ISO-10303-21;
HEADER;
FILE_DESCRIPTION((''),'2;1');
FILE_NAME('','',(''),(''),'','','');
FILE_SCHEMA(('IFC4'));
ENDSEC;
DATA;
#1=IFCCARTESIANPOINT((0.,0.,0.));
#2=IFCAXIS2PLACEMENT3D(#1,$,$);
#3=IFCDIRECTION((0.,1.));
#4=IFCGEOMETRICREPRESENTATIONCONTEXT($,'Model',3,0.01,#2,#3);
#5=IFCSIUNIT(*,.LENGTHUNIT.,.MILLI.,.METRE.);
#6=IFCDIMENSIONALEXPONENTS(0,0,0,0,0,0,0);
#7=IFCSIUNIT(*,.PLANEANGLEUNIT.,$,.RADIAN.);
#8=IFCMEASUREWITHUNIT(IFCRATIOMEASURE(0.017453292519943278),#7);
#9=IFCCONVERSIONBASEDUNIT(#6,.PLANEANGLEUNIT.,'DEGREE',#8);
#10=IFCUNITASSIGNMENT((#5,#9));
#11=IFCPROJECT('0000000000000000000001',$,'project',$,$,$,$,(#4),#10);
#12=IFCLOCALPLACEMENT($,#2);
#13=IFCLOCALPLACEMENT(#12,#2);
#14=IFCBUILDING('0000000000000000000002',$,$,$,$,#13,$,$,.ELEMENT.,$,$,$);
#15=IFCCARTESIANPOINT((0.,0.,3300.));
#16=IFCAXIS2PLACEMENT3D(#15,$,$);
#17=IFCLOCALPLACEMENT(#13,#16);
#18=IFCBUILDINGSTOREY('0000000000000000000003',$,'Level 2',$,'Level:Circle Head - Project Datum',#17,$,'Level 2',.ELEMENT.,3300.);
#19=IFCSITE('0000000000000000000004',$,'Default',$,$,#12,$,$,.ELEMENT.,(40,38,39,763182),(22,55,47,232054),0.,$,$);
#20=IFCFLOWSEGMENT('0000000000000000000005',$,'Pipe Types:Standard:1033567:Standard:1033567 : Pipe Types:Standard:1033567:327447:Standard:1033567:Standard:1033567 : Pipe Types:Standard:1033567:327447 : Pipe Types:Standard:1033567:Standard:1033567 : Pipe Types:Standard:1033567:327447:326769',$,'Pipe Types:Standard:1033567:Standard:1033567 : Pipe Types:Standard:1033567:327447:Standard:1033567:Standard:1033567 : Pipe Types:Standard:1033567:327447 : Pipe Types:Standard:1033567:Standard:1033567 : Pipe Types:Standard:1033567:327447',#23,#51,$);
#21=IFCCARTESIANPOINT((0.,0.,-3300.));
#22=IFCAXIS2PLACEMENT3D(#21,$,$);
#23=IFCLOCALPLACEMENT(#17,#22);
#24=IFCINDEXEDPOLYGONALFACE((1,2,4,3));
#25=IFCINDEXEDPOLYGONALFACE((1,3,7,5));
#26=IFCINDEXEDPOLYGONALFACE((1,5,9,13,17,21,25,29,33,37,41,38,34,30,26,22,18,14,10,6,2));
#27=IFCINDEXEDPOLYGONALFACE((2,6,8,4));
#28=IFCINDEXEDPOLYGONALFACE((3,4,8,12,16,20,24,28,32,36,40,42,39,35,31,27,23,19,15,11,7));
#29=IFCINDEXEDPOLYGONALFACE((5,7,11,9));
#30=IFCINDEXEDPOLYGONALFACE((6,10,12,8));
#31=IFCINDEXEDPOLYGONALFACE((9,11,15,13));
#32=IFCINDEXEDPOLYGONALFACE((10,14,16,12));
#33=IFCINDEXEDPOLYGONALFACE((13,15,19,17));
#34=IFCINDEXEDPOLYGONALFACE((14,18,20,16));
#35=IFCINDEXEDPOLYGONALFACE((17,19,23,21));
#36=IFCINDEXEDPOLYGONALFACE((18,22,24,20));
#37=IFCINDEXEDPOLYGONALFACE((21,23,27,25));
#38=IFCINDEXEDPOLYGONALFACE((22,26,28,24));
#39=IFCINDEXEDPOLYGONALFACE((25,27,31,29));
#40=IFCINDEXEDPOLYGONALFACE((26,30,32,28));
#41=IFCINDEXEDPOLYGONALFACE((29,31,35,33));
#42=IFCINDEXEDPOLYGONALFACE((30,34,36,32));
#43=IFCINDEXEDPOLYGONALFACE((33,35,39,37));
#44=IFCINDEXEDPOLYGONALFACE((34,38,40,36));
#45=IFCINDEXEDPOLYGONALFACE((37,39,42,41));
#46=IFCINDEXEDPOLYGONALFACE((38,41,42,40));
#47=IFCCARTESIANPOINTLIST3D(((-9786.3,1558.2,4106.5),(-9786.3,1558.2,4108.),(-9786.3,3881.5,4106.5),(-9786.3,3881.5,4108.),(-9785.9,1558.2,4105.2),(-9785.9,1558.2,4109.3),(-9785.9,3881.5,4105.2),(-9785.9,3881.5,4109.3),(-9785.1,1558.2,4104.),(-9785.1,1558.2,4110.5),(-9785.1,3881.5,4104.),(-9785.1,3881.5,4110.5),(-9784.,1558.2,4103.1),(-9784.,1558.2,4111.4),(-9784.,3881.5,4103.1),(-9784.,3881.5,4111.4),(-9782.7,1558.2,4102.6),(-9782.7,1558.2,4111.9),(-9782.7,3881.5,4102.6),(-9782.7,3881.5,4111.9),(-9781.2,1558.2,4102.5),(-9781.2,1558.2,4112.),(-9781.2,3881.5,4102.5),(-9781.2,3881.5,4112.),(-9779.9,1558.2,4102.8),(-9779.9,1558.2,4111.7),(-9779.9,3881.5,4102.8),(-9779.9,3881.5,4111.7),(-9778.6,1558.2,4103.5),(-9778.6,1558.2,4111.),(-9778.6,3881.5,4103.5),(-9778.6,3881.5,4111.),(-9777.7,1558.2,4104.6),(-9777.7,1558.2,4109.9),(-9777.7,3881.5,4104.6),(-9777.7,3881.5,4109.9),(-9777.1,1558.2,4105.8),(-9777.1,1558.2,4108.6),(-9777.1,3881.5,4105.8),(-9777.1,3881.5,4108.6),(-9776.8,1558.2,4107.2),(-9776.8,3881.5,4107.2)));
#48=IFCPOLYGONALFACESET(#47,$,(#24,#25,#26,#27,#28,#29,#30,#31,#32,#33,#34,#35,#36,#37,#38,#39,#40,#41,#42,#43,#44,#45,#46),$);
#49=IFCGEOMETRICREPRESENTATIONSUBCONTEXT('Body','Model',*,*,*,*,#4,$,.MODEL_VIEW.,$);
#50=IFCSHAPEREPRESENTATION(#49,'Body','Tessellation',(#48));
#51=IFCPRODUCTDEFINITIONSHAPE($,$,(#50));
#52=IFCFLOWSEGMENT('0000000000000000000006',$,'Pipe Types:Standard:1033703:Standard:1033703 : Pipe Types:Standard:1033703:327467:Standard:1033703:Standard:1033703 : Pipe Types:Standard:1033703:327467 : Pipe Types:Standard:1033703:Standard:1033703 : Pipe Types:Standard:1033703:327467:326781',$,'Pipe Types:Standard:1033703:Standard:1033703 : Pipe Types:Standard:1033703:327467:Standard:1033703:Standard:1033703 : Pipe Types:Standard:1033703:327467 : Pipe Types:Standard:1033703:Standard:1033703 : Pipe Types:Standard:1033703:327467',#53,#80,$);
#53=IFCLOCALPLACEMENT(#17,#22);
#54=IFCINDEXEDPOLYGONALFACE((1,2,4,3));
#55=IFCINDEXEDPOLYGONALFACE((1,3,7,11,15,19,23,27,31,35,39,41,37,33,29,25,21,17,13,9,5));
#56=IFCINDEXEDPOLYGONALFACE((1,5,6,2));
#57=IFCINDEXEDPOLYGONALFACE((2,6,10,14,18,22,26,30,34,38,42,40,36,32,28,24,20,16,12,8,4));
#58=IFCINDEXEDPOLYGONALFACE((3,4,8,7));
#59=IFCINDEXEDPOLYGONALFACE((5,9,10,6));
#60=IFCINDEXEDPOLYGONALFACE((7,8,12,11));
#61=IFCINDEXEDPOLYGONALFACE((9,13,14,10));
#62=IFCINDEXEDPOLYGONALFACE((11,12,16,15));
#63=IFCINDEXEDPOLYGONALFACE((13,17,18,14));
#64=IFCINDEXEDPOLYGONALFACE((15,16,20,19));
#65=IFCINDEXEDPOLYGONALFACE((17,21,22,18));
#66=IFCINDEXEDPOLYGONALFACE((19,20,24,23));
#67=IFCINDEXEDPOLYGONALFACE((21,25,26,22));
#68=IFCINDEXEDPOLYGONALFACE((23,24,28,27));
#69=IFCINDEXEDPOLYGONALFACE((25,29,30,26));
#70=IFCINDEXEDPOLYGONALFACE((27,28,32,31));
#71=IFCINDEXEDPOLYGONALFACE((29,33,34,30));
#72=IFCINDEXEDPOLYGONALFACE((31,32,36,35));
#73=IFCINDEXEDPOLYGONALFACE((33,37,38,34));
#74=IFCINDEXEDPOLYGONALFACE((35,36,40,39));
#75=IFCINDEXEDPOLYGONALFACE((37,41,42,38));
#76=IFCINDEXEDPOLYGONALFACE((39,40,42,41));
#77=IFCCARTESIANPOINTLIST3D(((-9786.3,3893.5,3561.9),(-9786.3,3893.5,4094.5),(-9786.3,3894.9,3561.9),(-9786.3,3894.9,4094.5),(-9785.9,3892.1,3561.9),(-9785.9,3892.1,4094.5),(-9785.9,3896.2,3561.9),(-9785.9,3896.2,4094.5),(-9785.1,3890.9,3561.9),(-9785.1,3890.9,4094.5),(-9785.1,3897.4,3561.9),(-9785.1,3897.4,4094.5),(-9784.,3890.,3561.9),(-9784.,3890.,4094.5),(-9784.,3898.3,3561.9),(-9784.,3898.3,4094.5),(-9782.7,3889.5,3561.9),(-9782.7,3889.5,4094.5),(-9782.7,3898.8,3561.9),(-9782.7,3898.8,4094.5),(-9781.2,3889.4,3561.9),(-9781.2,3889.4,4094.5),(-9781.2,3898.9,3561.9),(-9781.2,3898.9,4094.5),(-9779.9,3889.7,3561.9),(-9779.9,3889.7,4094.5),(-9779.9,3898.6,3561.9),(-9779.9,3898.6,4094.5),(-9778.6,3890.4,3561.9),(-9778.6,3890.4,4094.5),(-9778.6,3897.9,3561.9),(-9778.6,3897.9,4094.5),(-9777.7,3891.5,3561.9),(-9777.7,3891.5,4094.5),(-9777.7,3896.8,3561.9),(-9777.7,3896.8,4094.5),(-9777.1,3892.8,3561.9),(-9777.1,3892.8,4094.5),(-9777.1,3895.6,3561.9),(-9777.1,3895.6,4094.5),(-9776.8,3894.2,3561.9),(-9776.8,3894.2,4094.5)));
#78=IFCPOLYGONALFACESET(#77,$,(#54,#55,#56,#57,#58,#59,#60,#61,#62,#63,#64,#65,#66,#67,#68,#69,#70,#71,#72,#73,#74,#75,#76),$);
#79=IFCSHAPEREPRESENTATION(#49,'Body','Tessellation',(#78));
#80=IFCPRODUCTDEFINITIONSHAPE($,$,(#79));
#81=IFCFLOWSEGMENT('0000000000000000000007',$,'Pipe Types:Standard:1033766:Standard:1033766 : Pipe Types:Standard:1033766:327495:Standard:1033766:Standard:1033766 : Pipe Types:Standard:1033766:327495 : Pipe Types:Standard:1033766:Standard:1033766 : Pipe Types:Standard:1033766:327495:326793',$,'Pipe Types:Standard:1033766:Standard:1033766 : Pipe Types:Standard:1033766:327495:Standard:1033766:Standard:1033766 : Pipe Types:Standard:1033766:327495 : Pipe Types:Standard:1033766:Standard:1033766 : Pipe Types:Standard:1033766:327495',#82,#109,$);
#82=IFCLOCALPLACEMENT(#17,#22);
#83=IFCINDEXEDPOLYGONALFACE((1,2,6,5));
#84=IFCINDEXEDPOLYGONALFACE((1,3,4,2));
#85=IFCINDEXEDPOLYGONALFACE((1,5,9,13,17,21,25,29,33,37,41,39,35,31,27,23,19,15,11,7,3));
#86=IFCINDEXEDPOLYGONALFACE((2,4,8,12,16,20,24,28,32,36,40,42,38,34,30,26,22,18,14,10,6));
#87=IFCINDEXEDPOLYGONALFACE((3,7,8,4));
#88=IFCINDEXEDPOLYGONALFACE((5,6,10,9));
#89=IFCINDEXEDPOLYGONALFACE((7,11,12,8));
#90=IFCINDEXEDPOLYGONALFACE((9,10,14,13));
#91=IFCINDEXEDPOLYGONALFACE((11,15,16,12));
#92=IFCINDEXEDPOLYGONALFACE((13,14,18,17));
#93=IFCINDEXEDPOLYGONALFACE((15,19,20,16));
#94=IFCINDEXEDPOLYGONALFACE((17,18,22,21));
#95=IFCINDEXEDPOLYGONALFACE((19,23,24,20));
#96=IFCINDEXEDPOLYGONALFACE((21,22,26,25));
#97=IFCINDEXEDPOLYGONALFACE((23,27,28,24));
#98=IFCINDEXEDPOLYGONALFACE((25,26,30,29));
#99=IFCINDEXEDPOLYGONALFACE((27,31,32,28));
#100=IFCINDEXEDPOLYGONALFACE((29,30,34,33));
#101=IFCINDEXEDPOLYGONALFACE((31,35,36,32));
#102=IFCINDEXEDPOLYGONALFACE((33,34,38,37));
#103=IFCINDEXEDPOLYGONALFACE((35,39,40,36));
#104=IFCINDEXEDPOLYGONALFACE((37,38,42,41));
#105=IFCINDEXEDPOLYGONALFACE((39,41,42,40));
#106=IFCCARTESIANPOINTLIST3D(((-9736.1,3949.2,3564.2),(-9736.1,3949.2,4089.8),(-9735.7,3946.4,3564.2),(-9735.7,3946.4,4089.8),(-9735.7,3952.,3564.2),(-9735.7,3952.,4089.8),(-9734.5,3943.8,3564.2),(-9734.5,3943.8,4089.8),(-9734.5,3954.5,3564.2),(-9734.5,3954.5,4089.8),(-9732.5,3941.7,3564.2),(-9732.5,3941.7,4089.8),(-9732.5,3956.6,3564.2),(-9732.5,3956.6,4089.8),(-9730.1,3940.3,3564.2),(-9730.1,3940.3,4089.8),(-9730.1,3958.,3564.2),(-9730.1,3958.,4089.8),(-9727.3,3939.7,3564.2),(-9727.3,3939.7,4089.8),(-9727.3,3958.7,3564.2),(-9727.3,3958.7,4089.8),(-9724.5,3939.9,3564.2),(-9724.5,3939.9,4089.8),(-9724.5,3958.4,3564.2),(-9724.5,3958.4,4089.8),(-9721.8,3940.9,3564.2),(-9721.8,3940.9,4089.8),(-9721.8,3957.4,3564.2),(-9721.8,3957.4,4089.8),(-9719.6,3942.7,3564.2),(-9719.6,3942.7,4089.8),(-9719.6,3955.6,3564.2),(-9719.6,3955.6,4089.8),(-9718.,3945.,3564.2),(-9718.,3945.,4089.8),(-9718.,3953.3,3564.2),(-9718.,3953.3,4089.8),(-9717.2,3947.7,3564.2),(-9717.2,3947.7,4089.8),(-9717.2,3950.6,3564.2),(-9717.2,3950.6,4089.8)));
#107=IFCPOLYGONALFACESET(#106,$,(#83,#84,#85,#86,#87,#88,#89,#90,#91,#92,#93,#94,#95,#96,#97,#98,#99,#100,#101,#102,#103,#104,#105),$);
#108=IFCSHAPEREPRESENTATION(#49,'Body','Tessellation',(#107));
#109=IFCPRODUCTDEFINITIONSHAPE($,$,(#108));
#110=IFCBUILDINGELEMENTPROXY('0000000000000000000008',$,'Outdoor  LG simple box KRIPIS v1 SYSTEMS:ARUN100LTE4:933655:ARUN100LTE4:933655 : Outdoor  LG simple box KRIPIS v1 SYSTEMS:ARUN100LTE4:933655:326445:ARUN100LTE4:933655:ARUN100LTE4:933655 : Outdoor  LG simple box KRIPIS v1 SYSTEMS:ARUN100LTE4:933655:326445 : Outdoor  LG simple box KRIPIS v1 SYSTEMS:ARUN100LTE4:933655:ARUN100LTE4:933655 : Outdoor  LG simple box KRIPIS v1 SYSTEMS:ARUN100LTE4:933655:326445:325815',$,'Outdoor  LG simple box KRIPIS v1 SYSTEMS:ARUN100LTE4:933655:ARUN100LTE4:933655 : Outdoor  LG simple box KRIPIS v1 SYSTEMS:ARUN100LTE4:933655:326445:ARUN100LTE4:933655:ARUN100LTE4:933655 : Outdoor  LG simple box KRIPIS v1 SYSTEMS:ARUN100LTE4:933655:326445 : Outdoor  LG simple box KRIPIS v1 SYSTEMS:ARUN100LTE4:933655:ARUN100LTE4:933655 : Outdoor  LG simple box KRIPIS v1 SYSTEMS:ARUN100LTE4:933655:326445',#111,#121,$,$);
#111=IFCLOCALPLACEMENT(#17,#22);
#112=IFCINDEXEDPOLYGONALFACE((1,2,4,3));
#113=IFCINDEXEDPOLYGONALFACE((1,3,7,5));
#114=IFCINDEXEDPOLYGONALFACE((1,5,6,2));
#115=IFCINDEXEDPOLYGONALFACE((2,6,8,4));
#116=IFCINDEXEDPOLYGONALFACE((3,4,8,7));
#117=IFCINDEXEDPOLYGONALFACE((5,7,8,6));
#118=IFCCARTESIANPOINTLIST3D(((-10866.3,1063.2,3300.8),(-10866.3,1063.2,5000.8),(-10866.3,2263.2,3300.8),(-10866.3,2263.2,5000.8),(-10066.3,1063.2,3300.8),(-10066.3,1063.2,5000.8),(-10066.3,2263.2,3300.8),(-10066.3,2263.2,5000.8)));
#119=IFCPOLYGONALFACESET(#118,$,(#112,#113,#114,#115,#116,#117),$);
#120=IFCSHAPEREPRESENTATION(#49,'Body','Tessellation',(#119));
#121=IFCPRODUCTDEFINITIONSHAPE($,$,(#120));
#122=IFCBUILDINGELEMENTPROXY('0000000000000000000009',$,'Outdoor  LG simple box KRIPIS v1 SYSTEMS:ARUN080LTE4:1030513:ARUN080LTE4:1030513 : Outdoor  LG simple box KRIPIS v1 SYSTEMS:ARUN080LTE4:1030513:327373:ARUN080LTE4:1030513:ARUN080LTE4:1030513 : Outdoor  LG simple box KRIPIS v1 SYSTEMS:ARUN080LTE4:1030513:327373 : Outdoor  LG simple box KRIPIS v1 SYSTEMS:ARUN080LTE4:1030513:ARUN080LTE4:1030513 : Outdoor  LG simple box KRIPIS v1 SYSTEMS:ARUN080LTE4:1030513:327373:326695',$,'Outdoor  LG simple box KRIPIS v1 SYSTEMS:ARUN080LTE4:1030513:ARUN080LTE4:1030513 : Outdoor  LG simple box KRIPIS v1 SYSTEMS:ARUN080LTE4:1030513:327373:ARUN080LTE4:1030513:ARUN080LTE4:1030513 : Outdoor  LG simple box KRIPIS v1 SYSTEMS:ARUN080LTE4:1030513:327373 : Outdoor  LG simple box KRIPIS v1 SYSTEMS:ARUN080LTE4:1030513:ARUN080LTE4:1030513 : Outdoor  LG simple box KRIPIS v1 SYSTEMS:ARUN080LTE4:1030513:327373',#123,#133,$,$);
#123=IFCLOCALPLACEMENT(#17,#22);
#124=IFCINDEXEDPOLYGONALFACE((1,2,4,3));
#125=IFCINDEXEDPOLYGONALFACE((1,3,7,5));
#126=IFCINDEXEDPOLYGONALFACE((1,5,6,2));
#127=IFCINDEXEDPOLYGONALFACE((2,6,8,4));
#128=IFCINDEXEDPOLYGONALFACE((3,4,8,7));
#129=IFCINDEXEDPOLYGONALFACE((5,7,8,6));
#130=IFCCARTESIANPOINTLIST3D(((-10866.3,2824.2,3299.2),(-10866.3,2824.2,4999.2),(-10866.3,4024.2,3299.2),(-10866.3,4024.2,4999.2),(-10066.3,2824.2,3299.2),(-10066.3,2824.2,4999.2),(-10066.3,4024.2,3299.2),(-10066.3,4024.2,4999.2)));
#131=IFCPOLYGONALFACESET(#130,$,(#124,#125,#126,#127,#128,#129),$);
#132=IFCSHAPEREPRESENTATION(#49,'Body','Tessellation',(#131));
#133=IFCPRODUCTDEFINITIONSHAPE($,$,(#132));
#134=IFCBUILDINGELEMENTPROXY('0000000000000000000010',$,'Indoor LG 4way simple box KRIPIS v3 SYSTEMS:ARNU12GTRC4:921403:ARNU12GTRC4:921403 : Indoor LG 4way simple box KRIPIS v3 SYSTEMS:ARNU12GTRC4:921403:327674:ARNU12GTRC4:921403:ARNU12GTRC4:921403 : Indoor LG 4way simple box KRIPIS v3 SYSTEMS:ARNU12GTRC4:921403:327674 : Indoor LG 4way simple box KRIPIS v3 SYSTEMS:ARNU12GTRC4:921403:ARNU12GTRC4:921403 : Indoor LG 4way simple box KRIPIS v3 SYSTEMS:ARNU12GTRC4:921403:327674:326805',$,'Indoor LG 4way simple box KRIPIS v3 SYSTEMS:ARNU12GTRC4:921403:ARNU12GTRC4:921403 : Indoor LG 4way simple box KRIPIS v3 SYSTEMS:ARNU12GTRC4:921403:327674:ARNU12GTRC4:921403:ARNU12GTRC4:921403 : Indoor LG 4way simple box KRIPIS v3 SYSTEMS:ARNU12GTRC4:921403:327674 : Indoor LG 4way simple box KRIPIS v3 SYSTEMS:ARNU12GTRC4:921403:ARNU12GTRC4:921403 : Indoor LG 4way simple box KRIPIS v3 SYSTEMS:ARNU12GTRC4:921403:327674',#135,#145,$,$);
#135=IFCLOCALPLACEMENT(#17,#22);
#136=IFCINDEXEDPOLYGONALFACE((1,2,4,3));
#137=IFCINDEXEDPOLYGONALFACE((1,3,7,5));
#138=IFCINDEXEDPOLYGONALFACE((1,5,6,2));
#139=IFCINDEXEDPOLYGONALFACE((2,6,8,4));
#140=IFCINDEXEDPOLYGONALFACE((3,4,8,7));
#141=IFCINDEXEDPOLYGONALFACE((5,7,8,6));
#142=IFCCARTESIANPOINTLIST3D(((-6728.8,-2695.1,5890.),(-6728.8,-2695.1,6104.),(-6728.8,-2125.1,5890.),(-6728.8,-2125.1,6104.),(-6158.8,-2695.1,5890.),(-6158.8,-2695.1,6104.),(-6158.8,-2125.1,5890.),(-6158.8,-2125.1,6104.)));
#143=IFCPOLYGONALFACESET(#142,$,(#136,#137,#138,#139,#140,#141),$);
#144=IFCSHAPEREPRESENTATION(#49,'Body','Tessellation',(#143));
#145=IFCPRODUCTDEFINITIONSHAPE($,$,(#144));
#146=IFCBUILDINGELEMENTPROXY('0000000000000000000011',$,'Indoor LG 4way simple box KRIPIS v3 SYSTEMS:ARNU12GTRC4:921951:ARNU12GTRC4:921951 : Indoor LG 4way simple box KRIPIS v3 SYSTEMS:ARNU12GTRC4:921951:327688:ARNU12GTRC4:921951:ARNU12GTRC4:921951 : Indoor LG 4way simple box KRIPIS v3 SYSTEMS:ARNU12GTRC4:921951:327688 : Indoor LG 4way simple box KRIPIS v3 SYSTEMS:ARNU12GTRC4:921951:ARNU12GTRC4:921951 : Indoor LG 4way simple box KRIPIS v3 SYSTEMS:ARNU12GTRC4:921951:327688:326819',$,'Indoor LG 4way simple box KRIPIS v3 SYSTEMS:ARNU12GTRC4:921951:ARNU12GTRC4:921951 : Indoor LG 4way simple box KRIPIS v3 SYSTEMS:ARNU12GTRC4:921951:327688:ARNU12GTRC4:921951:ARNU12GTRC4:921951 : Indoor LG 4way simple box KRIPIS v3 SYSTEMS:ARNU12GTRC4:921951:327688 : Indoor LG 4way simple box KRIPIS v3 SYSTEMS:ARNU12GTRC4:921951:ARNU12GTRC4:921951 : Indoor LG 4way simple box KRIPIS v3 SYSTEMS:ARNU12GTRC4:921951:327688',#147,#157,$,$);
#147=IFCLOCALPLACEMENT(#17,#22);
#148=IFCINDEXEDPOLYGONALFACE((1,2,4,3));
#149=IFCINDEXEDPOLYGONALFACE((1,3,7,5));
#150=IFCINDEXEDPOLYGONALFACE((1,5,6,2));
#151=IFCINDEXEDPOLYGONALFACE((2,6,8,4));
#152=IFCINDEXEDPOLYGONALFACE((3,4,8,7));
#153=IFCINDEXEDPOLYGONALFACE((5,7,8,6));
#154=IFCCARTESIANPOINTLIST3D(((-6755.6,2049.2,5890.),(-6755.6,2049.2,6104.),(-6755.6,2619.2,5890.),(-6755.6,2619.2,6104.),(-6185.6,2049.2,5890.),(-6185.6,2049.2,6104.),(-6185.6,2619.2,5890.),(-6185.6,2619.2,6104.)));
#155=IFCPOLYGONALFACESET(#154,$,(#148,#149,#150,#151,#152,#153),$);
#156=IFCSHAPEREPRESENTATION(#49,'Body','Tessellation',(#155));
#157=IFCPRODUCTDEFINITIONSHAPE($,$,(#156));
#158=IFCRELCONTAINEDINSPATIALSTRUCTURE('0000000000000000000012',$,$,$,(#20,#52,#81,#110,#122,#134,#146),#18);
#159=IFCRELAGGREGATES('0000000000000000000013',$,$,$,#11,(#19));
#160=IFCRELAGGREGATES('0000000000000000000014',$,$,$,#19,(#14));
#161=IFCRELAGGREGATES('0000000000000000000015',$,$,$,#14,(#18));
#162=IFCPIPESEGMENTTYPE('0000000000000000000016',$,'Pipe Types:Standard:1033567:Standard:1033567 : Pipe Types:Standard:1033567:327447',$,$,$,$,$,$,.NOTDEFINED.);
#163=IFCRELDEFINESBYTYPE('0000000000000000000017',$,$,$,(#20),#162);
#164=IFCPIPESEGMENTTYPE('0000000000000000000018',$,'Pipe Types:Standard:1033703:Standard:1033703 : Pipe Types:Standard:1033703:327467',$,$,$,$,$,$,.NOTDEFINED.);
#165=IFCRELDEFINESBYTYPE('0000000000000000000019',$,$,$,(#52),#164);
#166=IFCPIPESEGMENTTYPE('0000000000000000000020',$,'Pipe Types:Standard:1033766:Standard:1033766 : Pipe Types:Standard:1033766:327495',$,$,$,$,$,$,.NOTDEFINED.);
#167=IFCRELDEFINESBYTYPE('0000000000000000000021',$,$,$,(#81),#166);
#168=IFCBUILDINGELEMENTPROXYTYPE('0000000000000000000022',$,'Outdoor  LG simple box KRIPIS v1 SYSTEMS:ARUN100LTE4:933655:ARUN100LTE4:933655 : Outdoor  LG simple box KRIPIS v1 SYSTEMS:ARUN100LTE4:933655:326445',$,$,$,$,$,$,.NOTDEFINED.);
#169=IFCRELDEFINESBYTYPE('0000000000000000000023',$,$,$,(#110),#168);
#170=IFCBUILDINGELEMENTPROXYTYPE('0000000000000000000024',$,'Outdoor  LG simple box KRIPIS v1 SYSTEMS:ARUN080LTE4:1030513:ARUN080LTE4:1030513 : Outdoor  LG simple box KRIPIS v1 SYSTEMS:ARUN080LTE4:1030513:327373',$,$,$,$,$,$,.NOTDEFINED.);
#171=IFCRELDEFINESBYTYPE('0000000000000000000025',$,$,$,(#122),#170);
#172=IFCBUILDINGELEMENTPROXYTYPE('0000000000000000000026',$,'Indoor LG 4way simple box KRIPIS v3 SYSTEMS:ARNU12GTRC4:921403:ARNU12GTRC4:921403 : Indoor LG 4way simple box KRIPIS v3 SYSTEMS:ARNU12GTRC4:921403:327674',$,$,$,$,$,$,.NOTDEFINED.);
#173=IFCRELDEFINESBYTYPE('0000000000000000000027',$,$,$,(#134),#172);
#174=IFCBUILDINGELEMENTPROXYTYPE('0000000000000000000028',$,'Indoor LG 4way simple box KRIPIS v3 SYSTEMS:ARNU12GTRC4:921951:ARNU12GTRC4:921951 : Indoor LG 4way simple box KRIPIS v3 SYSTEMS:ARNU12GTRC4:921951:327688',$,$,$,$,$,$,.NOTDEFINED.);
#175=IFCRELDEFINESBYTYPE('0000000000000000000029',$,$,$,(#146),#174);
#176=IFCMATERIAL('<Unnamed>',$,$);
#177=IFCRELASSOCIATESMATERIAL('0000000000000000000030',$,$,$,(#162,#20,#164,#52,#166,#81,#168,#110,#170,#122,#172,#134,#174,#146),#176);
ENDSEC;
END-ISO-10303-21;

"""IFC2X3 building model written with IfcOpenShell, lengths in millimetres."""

from ifc_helpers import new_model, entity, si_unit, converted_unit, direction, frame, frame_2d, origin, origin_2d_with_axis, place, context, subcontext, project, spatial, rectangle, circle, extrude, source, transform, mapped, material, type_object, type_shapes, element, save


model = new_model("IFC2X3")

# Units and contexts
model_context = context("Model", 3, precision=0.01, world=origin(), true_north=direction((0.0, 1.0)))
body_context = subcontext(model_context, "Body", "Model", "MODEL_VIEW")
ifc_project = project(units=[si_unit("LENGTHUNIT", "METRE", prefix="MILLI"), converted_unit("PLANEANGLEUNIT", "DEGREE", entity("IfcRatioMeasure", 0.017453292519943278), si_unit("PLANEANGLEUNIT", "RADIAN"), dimensions=[0, 0, 0, 0, 0, 0, 0])], contexts=[model_context])

# Site, building, storey
site_placement = place(None, origin())
site = spatial("IfcSite", under=ifc_project, at=site_placement, Name="Default", CompositionType="ELEMENT", RefLatitude=(40, 38, 39, 763182), RefLongitude=(22, 55, 47, 232054), RefElevation=0.0)
building_placement = place(site_placement, origin())
building = spatial("IfcBuilding", under=site, at=building_placement, CompositionType="ELEMENT")
storey_placement = place(building_placement, frame((0.0, 0.0, 3300.0)))
storey = spatial("IfcBuildingStorey", under=building, at=storey_placement, Name="Level 2", ObjectType="Level:Circle Head - Project Datum", LongName="Level 2", CompositionType="ELEMENT", Elevation=3300.0)

# Flow segments
ifc_material_1 = material(Name="<Unnamed>")
pipe_segment_type_1 = type_object("IfcPipeSegmentType", Name="Pipe Types:Standard:1033567:Standard:1033567 : Pipe Types:Standard:1033567:327447", PredefinedType="NOTDEFINED", material=ifc_material_1)
shared_shape_1 = source(origin(), body_context, "Body", "SweptSolid", [
    extrude(circle(Radius=4.8, at=origin_2d_with_axis()), frame((-9781.6, 1558.2, 4107.2), z_axis=(0.0, 1.0, 0.0), x_axis=(1.0, 0.0, 0.0)), (0.0, 0.0, 1.0), 2323.3),
])
type_shapes(pipe_segment_type_1, [shared_shape_1])
flow_segment_1_placement = place(storey_placement, frame((0.0, 0.0, -3300.0)))
element("IfcFlowSegment", 1, at=flow_segment_1_placement, inside=storey, type_object=pipe_segment_type_1, material=ifc_material_1, Name="Pipe Types:Standard:1033567:Standard:1033567 : Pipe Types:Standard:1033567:327447:Standard:1033567:Standard:1033567 : Pipe Types:Standard:1033567:327447 : Pipe Types:Standard:1033567:Standard:1033567 : Pipe Types:Standard:1033567:327447:326769", ObjectType="Pipe Types:Standard:1033567:Standard:1033567 : Pipe Types:Standard:1033567:327447:Standard:1033567:Standard:1033567 : Pipe Types:Standard:1033567:327447 : Pipe Types:Standard:1033567:Standard:1033567 : Pipe Types:Standard:1033567:327447", context=body_context, shape_type="MappedRepresentation", body=[
    mapped(shared_shape_1, transform((0.0, 0.0, 0.0), scale=1.0)),
])
pipe_segment_type_2 = type_object("IfcPipeSegmentType", Name="Pipe Types:Standard:1033703:Standard:1033703 : Pipe Types:Standard:1033703:327467", PredefinedType="NOTDEFINED", material=ifc_material_1)
shared_shape_2 = source(origin(), body_context, "Body", "SweptSolid", [
    extrude(circle(Radius=4.8, at=origin_2d_with_axis()), frame((-9781.6, 3894.2, 3561.9)), (0.0, 0.0, 1.0), 532.6),
])
type_shapes(pipe_segment_type_2, [shared_shape_2])
flow_segment_2_placement = place(storey_placement, frame((0.0, 0.0, -3300.0)))
element("IfcFlowSegment", 2, at=flow_segment_2_placement, inside=storey, type_object=pipe_segment_type_2, material=ifc_material_1, Name="Pipe Types:Standard:1033703:Standard:1033703 : Pipe Types:Standard:1033703:327467:Standard:1033703:Standard:1033703 : Pipe Types:Standard:1033703:327467 : Pipe Types:Standard:1033703:Standard:1033703 : Pipe Types:Standard:1033703:327467:326781", ObjectType="Pipe Types:Standard:1033703:Standard:1033703 : Pipe Types:Standard:1033703:327467:Standard:1033703:Standard:1033703 : Pipe Types:Standard:1033703:327467 : Pipe Types:Standard:1033703:Standard:1033703 : Pipe Types:Standard:1033703:327467", context=body_context, shape_type="MappedRepresentation", body=[
    mapped(shared_shape_2, transform((0.0, 0.0, 0.0), scale=1.0)),
])
pipe_segment_type_3 = type_object("IfcPipeSegmentType", Name="Pipe Types:Standard:1033766:Standard:1033766 : Pipe Types:Standard:1033766:327495", PredefinedType="NOTDEFINED", material=ifc_material_1)
shared_shape_3 = source(origin(), body_context, "Body", "SweptSolid", [
    extrude(circle(Radius=9.5, at=origin_2d_with_axis()), frame((-9726.6, 3949.2, 3564.2), z_axis=(0.0, 0.0, 1.0), x_axis=(-1.0, 0.0, 0.0)), (0.0, 0.0, 1.0), 525.6),
])
type_shapes(pipe_segment_type_3, [shared_shape_3])
flow_segment_3_placement = place(storey_placement, frame((0.0, 0.0, -3300.0)))
element("IfcFlowSegment", 3, at=flow_segment_3_placement, inside=storey, type_object=pipe_segment_type_3, material=ifc_material_1, Name="Pipe Types:Standard:1033766:Standard:1033766 : Pipe Types:Standard:1033766:327495:Standard:1033766:Standard:1033766 : Pipe Types:Standard:1033766:327495 : Pipe Types:Standard:1033766:Standard:1033766 : Pipe Types:Standard:1033766:327495:326793", ObjectType="Pipe Types:Standard:1033766:Standard:1033766 : Pipe Types:Standard:1033766:327495:Standard:1033766:Standard:1033766 : Pipe Types:Standard:1033766:327495 : Pipe Types:Standard:1033766:Standard:1033766 : Pipe Types:Standard:1033766:327495", context=body_context, shape_type="MappedRepresentation", body=[
    mapped(shared_shape_3, transform((0.0, 0.0, 0.0), scale=1.0)),
])

# Building element proxies
building_element_proxy_type_1 = type_object("IfcBuildingElementProxyType", Name="Outdoor  LG simple box KRIPIS v1 SYSTEMS:ARUN100LTE4:933655:ARUN100LTE4:933655 : Outdoor  LG simple box KRIPIS v1 SYSTEMS:ARUN100LTE4:933655:326445", PredefinedType="NOTDEFINED", material=ifc_material_1)
shared_shape_4 = source(origin(), body_context, "Body", "SweptSolid", [
    extrude(rectangle(XDim=1200.0, YDim=800.0, at=frame_2d((0.0, 0.0), x_axis=(1.0, 0.0))), frame((-10466.3, 1663.2, 3300.8), z_axis=(0.0, 0.0, 1.0), x_axis=(0.0, -1.0, 0.0)), (0.0, 0.0, 1.0), 1700.0),
])
type_shapes(building_element_proxy_type_1, [shared_shape_4])
proxy_1_placement = place(storey_placement, frame((0.0, 0.0, -3300.0)))
element("IfcBuildingElementProxy", 4, at=proxy_1_placement, inside=storey, type_object=building_element_proxy_type_1, material=ifc_material_1, Name="Outdoor  LG simple box KRIPIS v1 SYSTEMS:ARUN100LTE4:933655:ARUN100LTE4:933655 : Outdoor  LG simple box KRIPIS v1 SYSTEMS:ARUN100LTE4:933655:326445:ARUN100LTE4:933655:ARUN100LTE4:933655 : Outdoor  LG simple box KRIPIS v1 SYSTEMS:ARUN100LTE4:933655:326445 : Outdoor  LG simple box KRIPIS v1 SYSTEMS:ARUN100LTE4:933655:ARUN100LTE4:933655 : Outdoor  LG simple box KRIPIS v1 SYSTEMS:ARUN100LTE4:933655:326445:325815", ObjectType="Outdoor  LG simple box KRIPIS v1 SYSTEMS:ARUN100LTE4:933655:ARUN100LTE4:933655 : Outdoor  LG simple box KRIPIS v1 SYSTEMS:ARUN100LTE4:933655:326445:ARUN100LTE4:933655:ARUN100LTE4:933655 : Outdoor  LG simple box KRIPIS v1 SYSTEMS:ARUN100LTE4:933655:326445 : Outdoor  LG simple box KRIPIS v1 SYSTEMS:ARUN100LTE4:933655:ARUN100LTE4:933655 : Outdoor  LG simple box KRIPIS v1 SYSTEMS:ARUN100LTE4:933655:326445", context=body_context, shape_type="MappedRepresentation", body=[
    mapped(shared_shape_4, transform((0.0, 0.0, 0.0), scale=1.0)),
])
building_element_proxy_type_2 = type_object("IfcBuildingElementProxyType", Name="Outdoor  LG simple box KRIPIS v1 SYSTEMS:ARUN080LTE4:1030513:ARUN080LTE4:1030513 : Outdoor  LG simple box KRIPIS v1 SYSTEMS:ARUN080LTE4:1030513:327373", PredefinedType="NOTDEFINED", material=ifc_material_1)
shared_shape_5 = source(origin(), body_context, "Body", "SweptSolid", [
    extrude(rectangle(XDim=1200.0, YDim=800.0, at=origin_2d_with_axis()), frame((-10466.3, 3424.2, 3299.2), z_axis=(0.0, 0.0, 1.0), x_axis=(0.0, -1.0, 0.0)), (0.0, 0.0, 1.0), 1700.0),
])
type_shapes(building_element_proxy_type_2, [shared_shape_5])
proxy_2_placement = place(storey_placement, frame((0.0, 0.0, -3300.0)))
element("IfcBuildingElementProxy", 5, at=proxy_2_placement, inside=storey, type_object=building_element_proxy_type_2, material=ifc_material_1, Name="Outdoor  LG simple box KRIPIS v1 SYSTEMS:ARUN080LTE4:1030513:ARUN080LTE4:1030513 : Outdoor  LG simple box KRIPIS v1 SYSTEMS:ARUN080LTE4:1030513:327373:ARUN080LTE4:1030513:ARUN080LTE4:1030513 : Outdoor  LG simple box KRIPIS v1 SYSTEMS:ARUN080LTE4:1030513:327373 : Outdoor  LG simple box KRIPIS v1 SYSTEMS:ARUN080LTE4:1030513:ARUN080LTE4:1030513 : Outdoor  LG simple box KRIPIS v1 SYSTEMS:ARUN080LTE4:1030513:327373:326695", ObjectType="Outdoor  LG simple box KRIPIS v1 SYSTEMS:ARUN080LTE4:1030513:ARUN080LTE4:1030513 : Outdoor  LG simple box KRIPIS v1 SYSTEMS:ARUN080LTE4:1030513:327373:ARUN080LTE4:1030513:ARUN080LTE4:1030513 : Outdoor  LG simple box KRIPIS v1 SYSTEMS:ARUN080LTE4:1030513:327373 : Outdoor  LG simple box KRIPIS v1 SYSTEMS:ARUN080LTE4:1030513:ARUN080LTE4:1030513 : Outdoor  LG simple box KRIPIS v1 SYSTEMS:ARUN080LTE4:1030513:327373", context=body_context, shape_type="MappedRepresentation", body=[
    mapped(shared_shape_5, transform((0.0, 0.0, 0.0), scale=1.0)),
])
building_element_proxy_type_3 = type_object("IfcBuildingElementProxyType", Name="Indoor LG 4way simple box KRIPIS v3 SYSTEMS:ARNU12GTRC4:921403:ARNU12GTRC4:921403 : Indoor LG 4way simple box KRIPIS v3 SYSTEMS:ARNU12GTRC4:921403:327674", PredefinedType="NOTDEFINED", material=ifc_material_1)
shared_shape_6 = source(origin(), body_context, "Body", "SweptSolid", [
    extrude(rectangle(XDim=570.0, YDim=570.0, at=origin_2d_with_axis()), frame((-6443.8, -2410.1, 5890.0), z_axis=(0.0, 0.0, 1.0), x_axis=(0.0, 1.0, 0.0)), (0.0, 0.0, 1.0), 214.0),
])
type_shapes(building_element_proxy_type_3, [shared_shape_6])
proxy_3_placement = place(storey_placement, frame((0.0, 0.0, -3300.0)))
element("IfcBuildingElementProxy", 6, at=proxy_3_placement, inside=storey, type_object=building_element_proxy_type_3, material=ifc_material_1, Name="Indoor LG 4way simple box KRIPIS v3 SYSTEMS:ARNU12GTRC4:921403:ARNU12GTRC4:921403 : Indoor LG 4way simple box KRIPIS v3 SYSTEMS:ARNU12GTRC4:921403:327674:ARNU12GTRC4:921403:ARNU12GTRC4:921403 : Indoor LG 4way simple box KRIPIS v3 SYSTEMS:ARNU12GTRC4:921403:327674 : Indoor LG 4way simple box KRIPIS v3 SYSTEMS:ARNU12GTRC4:921403:ARNU12GTRC4:921403 : Indoor LG 4way simple box KRIPIS v3 SYSTEMS:ARNU12GTRC4:921403:327674:326805", ObjectType="Indoor LG 4way simple box KRIPIS v3 SYSTEMS:ARNU12GTRC4:921403:ARNU12GTRC4:921403 : Indoor LG 4way simple box KRIPIS v3 SYSTEMS:ARNU12GTRC4:921403:327674:ARNU12GTRC4:921403:ARNU12GTRC4:921403 : Indoor LG 4way simple box KRIPIS v3 SYSTEMS:ARNU12GTRC4:921403:327674 : Indoor LG 4way simple box KRIPIS v3 SYSTEMS:ARNU12GTRC4:921403:ARNU12GTRC4:921403 : Indoor LG 4way simple box KRIPIS v3 SYSTEMS:ARNU12GTRC4:921403:327674", context=body_context, shape_type="MappedRepresentation", body=[
    mapped(shared_shape_6, transform((0.0, 0.0, 0.0), scale=1.0)),
])
building_element_proxy_type_4 = type_object("IfcBuildingElementProxyType", Name="Indoor LG 4way simple box KRIPIS v3 SYSTEMS:ARNU12GTRC4:921951:ARNU12GTRC4:921951 : Indoor LG 4way simple box KRIPIS v3 SYSTEMS:ARNU12GTRC4:921951:327688", PredefinedType="NOTDEFINED", material=ifc_material_1)
shared_shape_7 = source(origin(), body_context, "Body", "SweptSolid", [
    extrude(rectangle(XDim=570.0, YDim=570.0, at=frame_2d((0.0, 0.0), x_axis=(1.0, 0.0))), frame((-6470.6, 2334.2, 5890.0), z_axis=(0.0, 0.0, 1.0), x_axis=(0.0, 1.0, 0.0)), (0.0, 0.0, 1.0), 214.0),
])
type_shapes(building_element_proxy_type_4, [shared_shape_7])
proxy_4_placement = place(storey_placement, frame((0.0, 0.0, -3300.0)))
element("IfcBuildingElementProxy", 7, at=proxy_4_placement, inside=storey, type_object=building_element_proxy_type_4, material=ifc_material_1, Name="Indoor LG 4way simple box KRIPIS v3 SYSTEMS:ARNU12GTRC4:921951:ARNU12GTRC4:921951 : Indoor LG 4way simple box KRIPIS v3 SYSTEMS:ARNU12GTRC4:921951:327688:ARNU12GTRC4:921951:ARNU12GTRC4:921951 : Indoor LG 4way simple box KRIPIS v3 SYSTEMS:ARNU12GTRC4:921951:327688 : Indoor LG 4way simple box KRIPIS v3 SYSTEMS:ARNU12GTRC4:921951:ARNU12GTRC4:921951 : Indoor LG 4way simple box KRIPIS v3 SYSTEMS:ARNU12GTRC4:921951:327688:326819", ObjectType="Indoor LG 4way simple box KRIPIS v3 SYSTEMS:ARNU12GTRC4:921951:ARNU12GTRC4:921951 : Indoor LG 4way simple box KRIPIS v3 SYSTEMS:ARNU12GTRC4:921951:327688:ARNU12GTRC4:921951:ARNU12GTRC4:921951 : Indoor LG 4way simple box KRIPIS v3 SYSTEMS:ARNU12GTRC4:921951:327688 : Indoor LG 4way simple box KRIPIS v3 SYSTEMS:ARNU12GTRC4:921951:ARNU12GTRC4:921951 : Indoor LG 4way simple box KRIPIS v3 SYSTEMS:ARNU12GTRC4:921951:327688", context=body_context, shape_type="MappedRepresentation", body=[
    mapped(shared_shape_7, transform((0.0, 0.0, 0.0), scale=1.0)),
])

save(model, "model.ifc")
